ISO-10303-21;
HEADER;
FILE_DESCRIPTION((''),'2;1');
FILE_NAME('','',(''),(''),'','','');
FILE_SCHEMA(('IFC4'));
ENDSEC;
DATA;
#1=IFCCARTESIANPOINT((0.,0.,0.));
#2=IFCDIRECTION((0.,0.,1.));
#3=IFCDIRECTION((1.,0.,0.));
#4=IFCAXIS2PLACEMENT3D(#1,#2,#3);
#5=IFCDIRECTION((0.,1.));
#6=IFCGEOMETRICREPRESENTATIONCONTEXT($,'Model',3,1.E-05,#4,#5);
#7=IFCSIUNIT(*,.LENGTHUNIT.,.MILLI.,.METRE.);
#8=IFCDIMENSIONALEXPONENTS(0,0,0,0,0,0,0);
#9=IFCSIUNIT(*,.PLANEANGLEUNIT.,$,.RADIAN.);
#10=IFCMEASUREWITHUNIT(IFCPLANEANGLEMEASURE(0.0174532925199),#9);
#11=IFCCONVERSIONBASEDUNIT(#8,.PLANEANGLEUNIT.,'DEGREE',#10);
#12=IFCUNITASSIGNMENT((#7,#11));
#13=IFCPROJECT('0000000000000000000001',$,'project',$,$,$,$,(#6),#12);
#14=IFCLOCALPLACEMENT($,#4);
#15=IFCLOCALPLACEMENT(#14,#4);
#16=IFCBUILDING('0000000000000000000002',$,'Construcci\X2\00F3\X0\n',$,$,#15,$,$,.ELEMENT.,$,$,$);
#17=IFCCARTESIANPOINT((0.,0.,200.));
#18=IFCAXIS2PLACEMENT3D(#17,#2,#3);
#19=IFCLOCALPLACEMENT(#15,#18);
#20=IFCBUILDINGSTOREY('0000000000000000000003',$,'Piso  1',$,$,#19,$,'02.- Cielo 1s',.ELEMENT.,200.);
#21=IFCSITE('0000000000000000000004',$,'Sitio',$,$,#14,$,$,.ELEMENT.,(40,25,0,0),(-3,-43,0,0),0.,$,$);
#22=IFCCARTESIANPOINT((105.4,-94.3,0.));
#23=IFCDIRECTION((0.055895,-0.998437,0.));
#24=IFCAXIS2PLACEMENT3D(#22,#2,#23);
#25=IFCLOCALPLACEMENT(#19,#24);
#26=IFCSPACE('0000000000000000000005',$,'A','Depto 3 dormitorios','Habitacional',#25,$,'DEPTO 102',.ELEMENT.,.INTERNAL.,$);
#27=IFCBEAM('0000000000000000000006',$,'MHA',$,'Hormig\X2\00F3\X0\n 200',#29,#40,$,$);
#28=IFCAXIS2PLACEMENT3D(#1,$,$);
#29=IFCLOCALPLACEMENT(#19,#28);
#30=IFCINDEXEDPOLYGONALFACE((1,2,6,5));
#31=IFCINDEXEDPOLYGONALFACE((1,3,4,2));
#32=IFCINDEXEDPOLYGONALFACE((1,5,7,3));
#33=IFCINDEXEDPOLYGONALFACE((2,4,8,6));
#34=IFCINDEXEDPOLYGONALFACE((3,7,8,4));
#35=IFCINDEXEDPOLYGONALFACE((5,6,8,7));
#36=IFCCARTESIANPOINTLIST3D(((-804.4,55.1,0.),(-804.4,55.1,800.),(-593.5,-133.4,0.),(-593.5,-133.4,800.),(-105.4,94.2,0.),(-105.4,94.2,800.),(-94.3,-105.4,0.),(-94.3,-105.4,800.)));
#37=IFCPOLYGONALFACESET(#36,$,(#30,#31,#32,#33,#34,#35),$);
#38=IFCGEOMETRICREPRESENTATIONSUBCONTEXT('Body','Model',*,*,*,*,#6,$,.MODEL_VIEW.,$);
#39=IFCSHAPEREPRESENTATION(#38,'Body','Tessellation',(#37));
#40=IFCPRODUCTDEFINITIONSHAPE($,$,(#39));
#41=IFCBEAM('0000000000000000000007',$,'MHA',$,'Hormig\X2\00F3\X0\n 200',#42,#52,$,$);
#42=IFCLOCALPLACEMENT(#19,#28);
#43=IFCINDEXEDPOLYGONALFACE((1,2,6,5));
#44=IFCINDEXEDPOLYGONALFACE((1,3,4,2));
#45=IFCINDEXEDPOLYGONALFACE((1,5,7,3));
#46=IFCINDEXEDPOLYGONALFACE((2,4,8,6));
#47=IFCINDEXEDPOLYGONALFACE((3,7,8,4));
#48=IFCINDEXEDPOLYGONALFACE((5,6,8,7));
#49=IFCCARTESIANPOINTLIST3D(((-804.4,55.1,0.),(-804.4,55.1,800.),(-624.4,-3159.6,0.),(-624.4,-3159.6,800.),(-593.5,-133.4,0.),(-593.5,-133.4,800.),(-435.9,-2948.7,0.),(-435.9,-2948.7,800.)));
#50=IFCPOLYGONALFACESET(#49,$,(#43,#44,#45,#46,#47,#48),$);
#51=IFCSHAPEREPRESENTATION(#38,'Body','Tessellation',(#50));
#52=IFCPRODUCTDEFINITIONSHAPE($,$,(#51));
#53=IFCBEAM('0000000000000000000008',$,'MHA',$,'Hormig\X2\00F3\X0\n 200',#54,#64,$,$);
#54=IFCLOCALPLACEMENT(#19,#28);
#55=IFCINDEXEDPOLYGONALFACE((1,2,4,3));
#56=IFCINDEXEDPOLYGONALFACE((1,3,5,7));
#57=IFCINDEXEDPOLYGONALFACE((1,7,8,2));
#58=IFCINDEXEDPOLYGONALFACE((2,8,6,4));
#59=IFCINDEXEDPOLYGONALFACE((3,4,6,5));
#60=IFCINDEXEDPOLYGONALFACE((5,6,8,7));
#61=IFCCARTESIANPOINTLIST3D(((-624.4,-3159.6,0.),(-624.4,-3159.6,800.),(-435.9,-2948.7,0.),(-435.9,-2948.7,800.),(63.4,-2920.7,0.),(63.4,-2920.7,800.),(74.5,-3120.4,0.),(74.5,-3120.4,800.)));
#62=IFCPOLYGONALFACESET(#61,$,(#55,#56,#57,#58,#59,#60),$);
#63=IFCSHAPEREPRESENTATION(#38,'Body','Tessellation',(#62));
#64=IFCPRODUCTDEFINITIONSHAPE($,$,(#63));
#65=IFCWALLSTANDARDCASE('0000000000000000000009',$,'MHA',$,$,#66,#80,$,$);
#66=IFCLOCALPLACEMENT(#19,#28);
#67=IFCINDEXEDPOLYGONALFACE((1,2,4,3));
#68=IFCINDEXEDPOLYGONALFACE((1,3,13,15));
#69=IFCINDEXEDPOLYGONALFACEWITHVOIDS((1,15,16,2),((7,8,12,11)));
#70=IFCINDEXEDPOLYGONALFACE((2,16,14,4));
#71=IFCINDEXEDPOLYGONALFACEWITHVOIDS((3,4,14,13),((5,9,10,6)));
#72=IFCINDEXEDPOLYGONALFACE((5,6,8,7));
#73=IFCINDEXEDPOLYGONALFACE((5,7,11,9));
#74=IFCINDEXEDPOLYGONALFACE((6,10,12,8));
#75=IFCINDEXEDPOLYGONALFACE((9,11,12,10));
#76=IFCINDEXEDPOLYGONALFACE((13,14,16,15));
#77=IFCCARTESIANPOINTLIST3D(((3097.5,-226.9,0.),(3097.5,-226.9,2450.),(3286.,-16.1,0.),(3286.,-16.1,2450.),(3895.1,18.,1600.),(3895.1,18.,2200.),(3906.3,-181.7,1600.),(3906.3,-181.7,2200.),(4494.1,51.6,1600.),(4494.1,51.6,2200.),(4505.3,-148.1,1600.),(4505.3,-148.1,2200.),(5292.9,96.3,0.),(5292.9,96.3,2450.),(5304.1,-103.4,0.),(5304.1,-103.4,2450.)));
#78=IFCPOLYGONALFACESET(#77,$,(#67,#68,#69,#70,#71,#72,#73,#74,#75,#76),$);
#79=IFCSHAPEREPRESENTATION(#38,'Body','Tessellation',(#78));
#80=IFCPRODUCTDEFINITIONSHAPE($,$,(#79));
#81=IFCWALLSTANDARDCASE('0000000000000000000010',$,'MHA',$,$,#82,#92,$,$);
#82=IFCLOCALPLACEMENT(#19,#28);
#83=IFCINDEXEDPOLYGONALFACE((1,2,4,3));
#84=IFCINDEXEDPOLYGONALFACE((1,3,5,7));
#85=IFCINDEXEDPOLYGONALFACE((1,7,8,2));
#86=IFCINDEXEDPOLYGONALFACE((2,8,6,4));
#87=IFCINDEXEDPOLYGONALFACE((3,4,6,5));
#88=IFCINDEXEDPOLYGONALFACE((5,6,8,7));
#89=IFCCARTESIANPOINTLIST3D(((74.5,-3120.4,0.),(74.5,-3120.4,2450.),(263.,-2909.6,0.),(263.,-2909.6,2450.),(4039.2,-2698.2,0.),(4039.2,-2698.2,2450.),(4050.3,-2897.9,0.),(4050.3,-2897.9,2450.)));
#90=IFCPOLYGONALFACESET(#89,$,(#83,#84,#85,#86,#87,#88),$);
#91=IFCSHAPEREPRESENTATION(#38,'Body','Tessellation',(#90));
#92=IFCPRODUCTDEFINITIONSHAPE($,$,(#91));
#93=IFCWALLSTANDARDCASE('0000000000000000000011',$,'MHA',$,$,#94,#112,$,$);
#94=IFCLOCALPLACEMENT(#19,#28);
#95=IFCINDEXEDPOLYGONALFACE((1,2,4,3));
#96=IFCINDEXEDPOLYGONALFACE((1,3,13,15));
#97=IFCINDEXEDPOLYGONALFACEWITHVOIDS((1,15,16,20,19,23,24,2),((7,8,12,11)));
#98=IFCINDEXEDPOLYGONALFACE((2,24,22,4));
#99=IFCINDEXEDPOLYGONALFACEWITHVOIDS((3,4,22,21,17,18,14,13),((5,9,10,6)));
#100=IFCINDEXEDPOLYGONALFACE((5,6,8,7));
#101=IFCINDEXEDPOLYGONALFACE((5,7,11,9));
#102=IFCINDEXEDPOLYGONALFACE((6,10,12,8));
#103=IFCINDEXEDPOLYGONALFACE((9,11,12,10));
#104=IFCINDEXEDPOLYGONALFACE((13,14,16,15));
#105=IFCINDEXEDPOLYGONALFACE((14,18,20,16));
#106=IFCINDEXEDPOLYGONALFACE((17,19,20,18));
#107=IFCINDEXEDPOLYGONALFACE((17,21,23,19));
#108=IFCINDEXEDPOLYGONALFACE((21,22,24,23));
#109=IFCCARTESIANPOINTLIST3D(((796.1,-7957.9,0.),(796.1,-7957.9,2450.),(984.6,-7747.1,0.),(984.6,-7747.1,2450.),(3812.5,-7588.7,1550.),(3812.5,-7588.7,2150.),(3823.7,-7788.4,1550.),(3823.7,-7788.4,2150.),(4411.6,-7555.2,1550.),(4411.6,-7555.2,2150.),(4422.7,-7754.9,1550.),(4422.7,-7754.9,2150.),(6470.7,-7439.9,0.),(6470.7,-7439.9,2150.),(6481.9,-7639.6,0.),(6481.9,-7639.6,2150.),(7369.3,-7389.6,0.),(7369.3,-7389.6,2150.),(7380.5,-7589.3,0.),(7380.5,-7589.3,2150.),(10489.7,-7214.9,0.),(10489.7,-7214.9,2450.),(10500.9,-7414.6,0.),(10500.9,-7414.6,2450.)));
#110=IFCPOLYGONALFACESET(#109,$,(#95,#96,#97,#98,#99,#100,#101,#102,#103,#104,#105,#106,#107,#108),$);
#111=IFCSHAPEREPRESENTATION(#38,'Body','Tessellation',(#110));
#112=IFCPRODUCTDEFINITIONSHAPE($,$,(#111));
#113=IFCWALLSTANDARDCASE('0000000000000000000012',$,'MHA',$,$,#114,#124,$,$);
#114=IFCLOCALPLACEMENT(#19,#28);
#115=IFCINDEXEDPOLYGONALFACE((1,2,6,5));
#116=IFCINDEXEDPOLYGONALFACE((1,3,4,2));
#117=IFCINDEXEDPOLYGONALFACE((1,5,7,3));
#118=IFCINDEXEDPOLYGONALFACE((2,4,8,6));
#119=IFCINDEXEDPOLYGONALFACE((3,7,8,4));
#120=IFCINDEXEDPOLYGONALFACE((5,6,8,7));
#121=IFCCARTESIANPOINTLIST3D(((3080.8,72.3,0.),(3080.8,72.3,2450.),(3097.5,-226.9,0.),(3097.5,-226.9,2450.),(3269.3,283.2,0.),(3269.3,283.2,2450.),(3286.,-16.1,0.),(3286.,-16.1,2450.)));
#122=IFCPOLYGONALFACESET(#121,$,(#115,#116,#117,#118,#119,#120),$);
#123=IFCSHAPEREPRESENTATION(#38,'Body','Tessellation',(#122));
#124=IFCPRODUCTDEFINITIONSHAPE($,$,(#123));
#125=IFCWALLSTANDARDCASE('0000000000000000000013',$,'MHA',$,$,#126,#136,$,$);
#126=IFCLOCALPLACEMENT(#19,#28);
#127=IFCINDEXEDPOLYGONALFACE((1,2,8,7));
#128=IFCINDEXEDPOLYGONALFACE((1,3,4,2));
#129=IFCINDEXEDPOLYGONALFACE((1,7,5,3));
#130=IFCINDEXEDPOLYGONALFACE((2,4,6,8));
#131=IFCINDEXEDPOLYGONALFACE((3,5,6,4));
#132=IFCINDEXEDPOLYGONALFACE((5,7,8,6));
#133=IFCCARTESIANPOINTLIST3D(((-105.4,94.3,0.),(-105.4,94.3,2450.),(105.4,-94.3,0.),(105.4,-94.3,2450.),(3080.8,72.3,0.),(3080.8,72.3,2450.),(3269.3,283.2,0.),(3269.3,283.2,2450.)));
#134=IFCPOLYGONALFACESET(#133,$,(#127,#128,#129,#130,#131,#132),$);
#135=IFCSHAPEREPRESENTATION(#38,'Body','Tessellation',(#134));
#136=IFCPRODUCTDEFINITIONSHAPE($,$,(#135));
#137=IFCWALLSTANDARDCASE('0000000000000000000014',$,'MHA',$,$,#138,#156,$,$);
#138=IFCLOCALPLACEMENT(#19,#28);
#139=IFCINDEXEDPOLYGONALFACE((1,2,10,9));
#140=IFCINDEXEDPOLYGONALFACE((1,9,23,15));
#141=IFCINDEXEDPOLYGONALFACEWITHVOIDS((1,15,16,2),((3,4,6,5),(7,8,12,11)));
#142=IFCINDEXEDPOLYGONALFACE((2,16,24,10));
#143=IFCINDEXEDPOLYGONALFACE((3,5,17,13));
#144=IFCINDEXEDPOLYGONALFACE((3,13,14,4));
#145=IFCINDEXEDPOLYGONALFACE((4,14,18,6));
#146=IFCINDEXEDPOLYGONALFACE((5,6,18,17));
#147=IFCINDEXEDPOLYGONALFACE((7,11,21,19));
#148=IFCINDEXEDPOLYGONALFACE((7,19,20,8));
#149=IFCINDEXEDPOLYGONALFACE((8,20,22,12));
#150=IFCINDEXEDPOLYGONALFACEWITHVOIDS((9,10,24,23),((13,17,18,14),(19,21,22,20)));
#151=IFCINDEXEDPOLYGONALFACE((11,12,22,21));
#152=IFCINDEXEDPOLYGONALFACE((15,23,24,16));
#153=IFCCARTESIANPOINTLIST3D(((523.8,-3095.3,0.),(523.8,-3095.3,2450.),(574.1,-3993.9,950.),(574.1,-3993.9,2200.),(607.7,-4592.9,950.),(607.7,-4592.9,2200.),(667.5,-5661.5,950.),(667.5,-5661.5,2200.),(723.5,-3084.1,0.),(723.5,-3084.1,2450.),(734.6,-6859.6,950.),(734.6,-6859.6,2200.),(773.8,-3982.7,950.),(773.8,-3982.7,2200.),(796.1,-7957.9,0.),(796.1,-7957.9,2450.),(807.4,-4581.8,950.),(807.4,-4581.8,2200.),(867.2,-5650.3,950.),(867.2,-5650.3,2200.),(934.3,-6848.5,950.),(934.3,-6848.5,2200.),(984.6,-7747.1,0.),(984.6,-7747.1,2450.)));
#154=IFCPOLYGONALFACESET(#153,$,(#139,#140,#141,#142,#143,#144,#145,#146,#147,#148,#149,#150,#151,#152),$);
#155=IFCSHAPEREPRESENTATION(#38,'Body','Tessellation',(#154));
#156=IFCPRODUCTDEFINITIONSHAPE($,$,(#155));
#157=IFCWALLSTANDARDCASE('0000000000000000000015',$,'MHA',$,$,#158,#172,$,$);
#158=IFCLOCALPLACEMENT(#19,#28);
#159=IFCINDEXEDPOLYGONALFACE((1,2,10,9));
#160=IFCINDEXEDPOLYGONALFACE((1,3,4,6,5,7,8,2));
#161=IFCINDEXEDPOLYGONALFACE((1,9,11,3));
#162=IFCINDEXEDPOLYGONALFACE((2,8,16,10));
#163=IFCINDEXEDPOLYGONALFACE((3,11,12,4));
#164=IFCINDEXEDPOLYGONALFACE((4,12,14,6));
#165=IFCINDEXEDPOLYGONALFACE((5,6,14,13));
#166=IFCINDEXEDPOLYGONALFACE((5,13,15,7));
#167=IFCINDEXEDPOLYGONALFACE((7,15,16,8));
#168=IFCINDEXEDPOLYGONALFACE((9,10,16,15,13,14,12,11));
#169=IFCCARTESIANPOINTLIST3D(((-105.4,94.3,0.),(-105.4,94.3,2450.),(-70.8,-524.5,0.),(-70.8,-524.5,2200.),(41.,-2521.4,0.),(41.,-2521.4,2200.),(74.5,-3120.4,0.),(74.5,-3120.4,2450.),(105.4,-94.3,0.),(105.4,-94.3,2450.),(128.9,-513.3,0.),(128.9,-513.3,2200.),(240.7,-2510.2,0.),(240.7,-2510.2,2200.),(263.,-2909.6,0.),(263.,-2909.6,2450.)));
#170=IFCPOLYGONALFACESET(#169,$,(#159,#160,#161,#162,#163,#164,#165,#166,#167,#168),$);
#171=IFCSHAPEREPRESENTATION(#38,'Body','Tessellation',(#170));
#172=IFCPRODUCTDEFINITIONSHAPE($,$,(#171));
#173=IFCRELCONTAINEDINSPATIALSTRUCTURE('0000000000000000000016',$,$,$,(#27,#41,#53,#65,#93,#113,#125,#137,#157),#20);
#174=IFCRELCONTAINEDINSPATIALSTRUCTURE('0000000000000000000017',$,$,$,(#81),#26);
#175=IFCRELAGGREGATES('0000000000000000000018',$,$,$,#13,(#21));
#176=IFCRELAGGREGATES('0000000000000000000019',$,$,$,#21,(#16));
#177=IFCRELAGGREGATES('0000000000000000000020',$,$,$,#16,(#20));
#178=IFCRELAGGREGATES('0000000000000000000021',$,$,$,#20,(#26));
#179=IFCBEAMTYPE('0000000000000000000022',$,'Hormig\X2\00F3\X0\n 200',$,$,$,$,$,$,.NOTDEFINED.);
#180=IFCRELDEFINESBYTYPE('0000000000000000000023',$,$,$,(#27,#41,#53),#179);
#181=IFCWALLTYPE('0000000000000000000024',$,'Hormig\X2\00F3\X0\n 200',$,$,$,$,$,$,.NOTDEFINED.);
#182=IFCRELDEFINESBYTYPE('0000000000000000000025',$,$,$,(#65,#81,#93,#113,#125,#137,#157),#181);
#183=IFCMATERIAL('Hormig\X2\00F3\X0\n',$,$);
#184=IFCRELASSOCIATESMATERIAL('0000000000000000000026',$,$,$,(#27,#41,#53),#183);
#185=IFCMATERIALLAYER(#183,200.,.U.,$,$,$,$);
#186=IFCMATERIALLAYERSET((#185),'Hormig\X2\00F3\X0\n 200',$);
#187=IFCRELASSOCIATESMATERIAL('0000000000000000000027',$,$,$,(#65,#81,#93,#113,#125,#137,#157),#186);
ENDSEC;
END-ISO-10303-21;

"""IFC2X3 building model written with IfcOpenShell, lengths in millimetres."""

from ifc_helpers import new_model, entity, si_unit, converted_unit, direction, frame, origin_with_axes, origin_2d_with_axis, place, context, subcontext, project, spatial, polyline, rectangle, outline, extrude, material, layer, layer_set, layer_usage, type_object, element, save


model = new_model("IFC2X3")

# Units and contexts
model_context = context("Model", 3, precision=1e-05, world=origin_with_axes(), true_north=direction((0.0, 1.0)))
body_context = subcontext(model_context, "Body", "Model", "MODEL_VIEW")
ifc_project = project(units=[si_unit("LENGTHUNIT", "METRE", prefix="MILLI"), converted_unit("PLANEANGLEUNIT", "DEGREE", entity("IfcPlaneAngleMeasure", 0.0174532925199), si_unit("PLANEANGLEUNIT", "RADIAN"), dimensions=[0, 0, 0, 0, 0, 0, 0])], contexts=[model_context])

# Site, building, storey
site_placement = place(None, origin_with_axes())
site = spatial("IfcSite", under=ifc_project, at=site_placement, Name="Sitio", CompositionType="ELEMENT", RefLatitude=(40, 25, 0, 0), RefLongitude=(-3, -43, 0, 0), RefElevation=0.0)
building_placement = place(site_placement, origin_with_axes())
building = spatial("IfcBuilding", under=site, at=building_placement, Name="Construcción", CompositionType="ELEMENT")
storey_placement = place(building_placement, frame((0.0, 0.0, 200.0), z_axis=(0.0, 0.0, 1.0), x_axis=(1.0, 0.0, 0.0)))
storey = spatial("IfcBuildingStorey", under=building, at=storey_placement, Name="Piso  1", LongName="02.- Cielo 1s", CompositionType="ELEMENT", Elevation=200.0)

# Beams
ifc_material = material(Name="Hormigón")
beam_type = type_object("IfcBeamType", Name="Hormigón 200", PredefinedType="NOTDEFINED")
beam_1_placement = place(storey_placement, frame((-99.9, -5.6, 0.0), z_axis=(0.0, 0.0, 1.0), x_axis=(-0.998437, -0.055889, 0.0)))
element("IfcBeam", 1, at=beam_1_placement, inside=storey, type_object=beam_type, material=ifc_material, Name="MHA", ObjectType="Hormigón 200", context=body_context, shape_type="SweptSolid", body=[
    extrude(outline(polyline([(0.0, -100.0), (700.0, -100.0), (500.0, 100.0), (0.0, 100.0), (0.0, -100.0)])), origin_with_axes(), (0.0, 0.0, 1.0), 800.0),
])
beam_2_placement = place(storey_placement, frame((-698.9, -39.1, 0.0), z_axis=(0.0, 0.0, 1.0), x_axis=(0.055889, -0.998437, 0.0)))
element("IfcBeam", 2, at=beam_2_placement, inside=storey, type_object=beam_type, material=ifc_material, Name="MHA", ObjectType="Hormigón 200", context=body_context, shape_type="SweptSolid", body=[
    extrude(outline(polyline([(-100.0, -100.0), (3119.7, -100.0), (2919.7, 100.0), (100.0, 100.0), (-100.0, -100.0)])), origin_with_axes(), (0.0, 0.0, 1.0), 800.0),
])
beam_3_placement = place(storey_placement, frame((68.9, -3020.6, 0.0), z_axis=(0.0, 0.0, 1.0), x_axis=(-0.998437, -0.055889, 0.0)))
element("IfcBeam", 3, at=beam_3_placement, inside=storey, type_object=beam_type, material=ifc_material, Name="MHA", ObjectType="Hormigón 200", context=body_context, shape_type="SweptSolid", body=[
    extrude(outline(polyline([(0.0, -100.0), (500.0, -100.0), (700.0, 100.0), (0.0, 100.0), (0.0, -100.0)])), origin_with_axes(), (0.0, 0.0, 1.0), 800.0),
])

# Wall, opening
ifc_layer_1 = layer(ifc_material, 200.0, ventilated="UNKNOWN")
ifc_layer_set_1 = layer_set([ifc_layer_1], Name="Hormigón 200")
ifc_layer_usage_1 = layer_usage(ifc_layer_set_1, "AXIS2", "POSITIVE", -100.0)
wall_type_1 = type_object("IfcWallType", Name="Hormigón 200", PredefinedType="NOTDEFINED")
wall_1_placement = place(storey_placement, frame((3191.8, -121.5, 0.0), z_axis=(0.0, 0.0, 1.0), x_axis=(0.998437, 0.055895, 0.0)))
wall_1 = element("IfcWallStandardCase", 4, at=wall_1_placement, inside=storey, type_object=wall_type_1, material=ifc_layer_usage_1, Name="MHA", context=body_context, shape_type="SweptSolid", body=[
    extrude(outline(polyline([(-100.0, -100.0), (2110.0, -100.0), (2110.0, 100.0), (100.0, 100.0), (-100.0, -100.0)])), origin_with_axes(), (0.0, 0.0, 1.0), 2450.0),
])
opening_1_placement = place(wall_1_placement, frame((1010.0, 0.0, 1600.0), z_axis=(0.0, 0.0, 1.0), x_axis=(1.0, 0.0, 0.0)))
element("IfcOpeningElement", 5, at=opening_1_placement, cuts=wall_1, context=body_context, shape_type="SweptSolid", body=[
    extrude(rectangle(XDim=600.0, YDim=600.0, at=origin_2d_with_axis()), frame((0.0, 200.0, 300.0), z_axis=(0.0, -1.0, 0.0), x_axis=(1.0, 0.0, 0.0)), (0.0, 0.0, 1.0), 600.0),
])

# Shared definitions
space_placement = place(storey_placement, frame((105.4, -94.3, 0.0), z_axis=(0.0, 0.0, 1.0), x_axis=(0.055895, -0.998437, 0.0)))
space = spatial("IfcSpace", under=storey, at=space_placement, Name="A", Description="Depto 3 dormitorios", ObjectType="Habitacional", LongName="DEPTO 102", CompositionType="ELEMENT", InteriorOrExteriorSpace="INTERNAL")

# Wall
ifc_layer_usage_2 = layer_usage(ifc_layer_set_1, "AXIS2", "POSITIVE", -100.0)
wall_2_placement = place(space_placement, frame((2919.7, -100.0, 0.0), z_axis=(0.0, 0.0, 1.0), x_axis=(0.0, 1.0, 0.0)))
element("IfcWallStandardCase", 6, at=wall_2_placement, inside=space, type_object=wall_type_1, material=ifc_layer_usage_2, Name="MHA", context=body_context, shape_type="SweptSolid", body=[
    extrude(outline(polyline([(-100.0, -100.0), (3882.0, -100.0), (3882.0, 100.0), (100.0, 100.0), (-100.0, -100.0)])), origin_with_axes(), (0.0, 0.0, 1.0), 2450.0),
])

# Wall, openings
ifc_layer_usage_3 = layer_usage(ifc_layer_set_1, "AXIS2", "POSITIVE", -100.0)
wall_3_placement = place(storey_placement, frame((890.3, -7852.5, 0.0), z_axis=(0.0, 0.0, 1.0), x_axis=(0.998436, 0.0559, 0.0)))
wall_3 = element("IfcWallStandardCase", 7, at=wall_3_placement, inside=storey, type_object=wall_type_1, material=ifc_layer_usage_3, Name="MHA", context=body_context, shape_type="SweptSolid", body=[
    extrude(outline(polyline([(-100.0, -100.0), (9620.0, -100.0), (9620.0, 100.0), (100.0, 100.0), (-100.0, -100.0)])), origin_with_axes(), (0.0, 0.0, 1.0), 2450.0),
])
opening_2_placement = place(wall_3_placement, frame((3232.4, 0.0, 1550.0), z_axis=(0.0, 0.0, 1.0), x_axis=(1.0, 0.0, 0.0)))
element("IfcOpeningElement", 8, at=opening_2_placement, cuts=wall_3, context=body_context, shape_type="SweptSolid", body=[
    extrude(rectangle(XDim=600.0, YDim=600.0, at=origin_2d_with_axis()), frame((0.0, -200.0, 300.0), z_axis=(0.0, -1.0, 0.0), x_axis=(1.0, 0.0, 0.0)), (0.0, 0.0, -1.0), 600.0),
])
opening_3_placement = place(wall_3_placement, frame((6044.8, 0.0, 0.0), z_axis=(0.0, 0.0, 1.0), x_axis=(1.0, 0.0, 0.0)))
element("IfcOpeningElement", 9, at=opening_3_placement, cuts=wall_3, context=body_context, shape_type="SweptSolid", body=[
    extrude(rectangle(XDim=900.0, YDim=2150.0, at=origin_2d_with_axis()), frame((0.0, -200.0, 1075.0), z_axis=(0.0, -1.0, 0.0), x_axis=(-1.0, 0.0, 0.0)), (0.0, 0.0, -1.0), 600.0),
    extrude(rectangle(XDim=974.0, YDim=2187.0, at=origin_2d_with_axis()), frame((0.0, 100.0, 1093.5), z_axis=(0.0, 1.0, 0.0), x_axis=(-1.0, 0.0, 0.0)), (0.0, 0.0, 1.0), 200.0),
])

# Walls
ifc_layer_usage_4 = layer_usage(ifc_layer_set_1, "AXIS2", "POSITIVE", -100.0)
wall_4_placement = place(storey_placement, frame((3191.8, -121.5, 0.0), z_axis=(0.0, 0.0, 1.0), x_axis=(-0.055889, 0.998437, 0.0)))
element("IfcWallStandardCase", 10, at=wall_4_placement, inside=storey, type_object=wall_type_1, material=ifc_layer_usage_4, Name="MHA", context=body_context, shape_type="SweptSolid", body=[
    extrude(outline(polyline([(100.0, -100.0), (399.7, -100.0), (199.7, 100.0), (-100.0, 100.0), (100.0, -100.0)])), origin_with_axes(), (0.0, 0.0, 1.0), 2450.0),
])
ifc_layer_usage_5 = layer_usage(ifc_layer_set_1, "AXIS2", "POSITIVE", -100.0)
wall_5_placement = place(storey_placement, frame((0.0, 0.0, 0.0), z_axis=(0.0, 0.0, 1.0), x_axis=(0.998437, 0.055895, 0.0)))
element("IfcWallStandardCase", 11, at=wall_5_placement, inside=storey, type_object=wall_type_1, material=ifc_layer_usage_5, Name="MHA", context=body_context, shape_type="SweptSolid", body=[
    extrude(outline(polyline([(100.0, -100.0), (3080.0, -100.0), (3280.0, 100.0), (-100.0, 100.0), (100.0, -100.0)])), origin_with_axes(), (0.0, 0.0, 1.0), 2450.0),
])

# Wall, openings
ifc_layer_usage_6 = layer_usage(ifc_layer_set_1, "AXIS2", "POSITIVE", -100.0)
wall_6_placement = place(storey_placement, frame((890.3, -7852.5, 0.0), z_axis=(0.0, 0.0, 1.0), x_axis=(-0.055895, 0.998437, 0.0)))
wall_6 = element("IfcWallStandardCase", 12, at=wall_6_placement, inside=storey, type_object=wall_type_1, material=ifc_layer_usage_6, Name="MHA", context=body_context, shape_type="SweptSolid", body=[
    extrude(outline(polyline([(100.0, -100.0), (4770.3, -100.0), (4770.3, 100.0), (-100.0, 100.0), (100.0, -100.0)])), origin_with_axes(), (0.0, 0.0, 1.0), 2450.0),
])
opening_4_placement = place(wall_6_placement, frame((3570.3, 0.0, 950.0), z_axis=(0.0, 0.0, 1.0), x_axis=(1.0, 0.0, 0.0)))
element("IfcOpeningElement", 13, at=opening_4_placement, cuts=wall_6, context=body_context, shape_type="SweptSolid", body=[
    extrude(rectangle(XDim=600.0, YDim=1250.0, at=origin_2d_with_axis()), frame((0.0, 200.0, 625.0), z_axis=(0.0, 1.0, 0.0), x_axis=(1.0, 0.0, 0.0)), (0.0, 0.0, -1.0), 600.0),
])
opening_5_placement = place(wall_6_placement, frame((1600.0, 0.0, 950.0), z_axis=(0.0, 0.0, 1.0), x_axis=(1.0, 0.0, 0.0)))
element("IfcOpeningElement", 14, at=opening_5_placement, cuts=wall_6, context=body_context, shape_type="SweptSolid", body=[
    extrude(rectangle(XDim=1200.0, YDim=1250.0, at=origin_2d_with_axis()), frame((0.0, 200.0, 625.0), z_axis=(0.0, 1.0, 0.0), x_axis=(1.0, 0.0, 0.0)), (0.0, 0.0, -1.0), 600.0),
])

# Wall, opening
ifc_layer_usage_7 = layer_usage(ifc_layer_set_1, "AXIS2", "POSITIVE", -100.0)
wall_7_placement = place(storey_placement, frame((168.8, -3015.0, 0.0), z_axis=(0.0, 0.0, 1.0), x_axis=(-0.055895, 0.998437, 0.0)))
wall_7 = element("IfcWallStandardCase", 15, at=wall_7_placement, inside=storey, type_object=wall_type_1, material=ifc_layer_usage_7, Name="MHA", context=body_context, shape_type="SweptSolid", body=[
    extrude(outline(polyline([(100.0, -100.0), (2919.7, -100.0), (3119.7, 100.0), (-100.0, 100.0), (100.0, -100.0)])), origin_with_axes(), (0.0, 0.0, 1.0), 2450.0),
])
opening_6_placement = place(wall_7_placement, frame((1500.0, 0.0, 0.0), z_axis=(0.0, 0.0, 1.0), x_axis=(1.0, 0.0, 0.0)))
element("IfcOpeningElement", 16, at=opening_6_placement, cuts=wall_7, context=body_context, shape_type="SweptSolid", body=[
    extrude(rectangle(XDim=2000.0, YDim=2200.0, at=origin_2d_with_axis()), frame((0.0, 200.0, 1100.0), z_axis=(0.0, 1.0, 0.0), x_axis=(-1.0, 0.0, 0.0)), (0.0, 0.0, -1.0), 600.0),
])

save(model, "model.ifc")
